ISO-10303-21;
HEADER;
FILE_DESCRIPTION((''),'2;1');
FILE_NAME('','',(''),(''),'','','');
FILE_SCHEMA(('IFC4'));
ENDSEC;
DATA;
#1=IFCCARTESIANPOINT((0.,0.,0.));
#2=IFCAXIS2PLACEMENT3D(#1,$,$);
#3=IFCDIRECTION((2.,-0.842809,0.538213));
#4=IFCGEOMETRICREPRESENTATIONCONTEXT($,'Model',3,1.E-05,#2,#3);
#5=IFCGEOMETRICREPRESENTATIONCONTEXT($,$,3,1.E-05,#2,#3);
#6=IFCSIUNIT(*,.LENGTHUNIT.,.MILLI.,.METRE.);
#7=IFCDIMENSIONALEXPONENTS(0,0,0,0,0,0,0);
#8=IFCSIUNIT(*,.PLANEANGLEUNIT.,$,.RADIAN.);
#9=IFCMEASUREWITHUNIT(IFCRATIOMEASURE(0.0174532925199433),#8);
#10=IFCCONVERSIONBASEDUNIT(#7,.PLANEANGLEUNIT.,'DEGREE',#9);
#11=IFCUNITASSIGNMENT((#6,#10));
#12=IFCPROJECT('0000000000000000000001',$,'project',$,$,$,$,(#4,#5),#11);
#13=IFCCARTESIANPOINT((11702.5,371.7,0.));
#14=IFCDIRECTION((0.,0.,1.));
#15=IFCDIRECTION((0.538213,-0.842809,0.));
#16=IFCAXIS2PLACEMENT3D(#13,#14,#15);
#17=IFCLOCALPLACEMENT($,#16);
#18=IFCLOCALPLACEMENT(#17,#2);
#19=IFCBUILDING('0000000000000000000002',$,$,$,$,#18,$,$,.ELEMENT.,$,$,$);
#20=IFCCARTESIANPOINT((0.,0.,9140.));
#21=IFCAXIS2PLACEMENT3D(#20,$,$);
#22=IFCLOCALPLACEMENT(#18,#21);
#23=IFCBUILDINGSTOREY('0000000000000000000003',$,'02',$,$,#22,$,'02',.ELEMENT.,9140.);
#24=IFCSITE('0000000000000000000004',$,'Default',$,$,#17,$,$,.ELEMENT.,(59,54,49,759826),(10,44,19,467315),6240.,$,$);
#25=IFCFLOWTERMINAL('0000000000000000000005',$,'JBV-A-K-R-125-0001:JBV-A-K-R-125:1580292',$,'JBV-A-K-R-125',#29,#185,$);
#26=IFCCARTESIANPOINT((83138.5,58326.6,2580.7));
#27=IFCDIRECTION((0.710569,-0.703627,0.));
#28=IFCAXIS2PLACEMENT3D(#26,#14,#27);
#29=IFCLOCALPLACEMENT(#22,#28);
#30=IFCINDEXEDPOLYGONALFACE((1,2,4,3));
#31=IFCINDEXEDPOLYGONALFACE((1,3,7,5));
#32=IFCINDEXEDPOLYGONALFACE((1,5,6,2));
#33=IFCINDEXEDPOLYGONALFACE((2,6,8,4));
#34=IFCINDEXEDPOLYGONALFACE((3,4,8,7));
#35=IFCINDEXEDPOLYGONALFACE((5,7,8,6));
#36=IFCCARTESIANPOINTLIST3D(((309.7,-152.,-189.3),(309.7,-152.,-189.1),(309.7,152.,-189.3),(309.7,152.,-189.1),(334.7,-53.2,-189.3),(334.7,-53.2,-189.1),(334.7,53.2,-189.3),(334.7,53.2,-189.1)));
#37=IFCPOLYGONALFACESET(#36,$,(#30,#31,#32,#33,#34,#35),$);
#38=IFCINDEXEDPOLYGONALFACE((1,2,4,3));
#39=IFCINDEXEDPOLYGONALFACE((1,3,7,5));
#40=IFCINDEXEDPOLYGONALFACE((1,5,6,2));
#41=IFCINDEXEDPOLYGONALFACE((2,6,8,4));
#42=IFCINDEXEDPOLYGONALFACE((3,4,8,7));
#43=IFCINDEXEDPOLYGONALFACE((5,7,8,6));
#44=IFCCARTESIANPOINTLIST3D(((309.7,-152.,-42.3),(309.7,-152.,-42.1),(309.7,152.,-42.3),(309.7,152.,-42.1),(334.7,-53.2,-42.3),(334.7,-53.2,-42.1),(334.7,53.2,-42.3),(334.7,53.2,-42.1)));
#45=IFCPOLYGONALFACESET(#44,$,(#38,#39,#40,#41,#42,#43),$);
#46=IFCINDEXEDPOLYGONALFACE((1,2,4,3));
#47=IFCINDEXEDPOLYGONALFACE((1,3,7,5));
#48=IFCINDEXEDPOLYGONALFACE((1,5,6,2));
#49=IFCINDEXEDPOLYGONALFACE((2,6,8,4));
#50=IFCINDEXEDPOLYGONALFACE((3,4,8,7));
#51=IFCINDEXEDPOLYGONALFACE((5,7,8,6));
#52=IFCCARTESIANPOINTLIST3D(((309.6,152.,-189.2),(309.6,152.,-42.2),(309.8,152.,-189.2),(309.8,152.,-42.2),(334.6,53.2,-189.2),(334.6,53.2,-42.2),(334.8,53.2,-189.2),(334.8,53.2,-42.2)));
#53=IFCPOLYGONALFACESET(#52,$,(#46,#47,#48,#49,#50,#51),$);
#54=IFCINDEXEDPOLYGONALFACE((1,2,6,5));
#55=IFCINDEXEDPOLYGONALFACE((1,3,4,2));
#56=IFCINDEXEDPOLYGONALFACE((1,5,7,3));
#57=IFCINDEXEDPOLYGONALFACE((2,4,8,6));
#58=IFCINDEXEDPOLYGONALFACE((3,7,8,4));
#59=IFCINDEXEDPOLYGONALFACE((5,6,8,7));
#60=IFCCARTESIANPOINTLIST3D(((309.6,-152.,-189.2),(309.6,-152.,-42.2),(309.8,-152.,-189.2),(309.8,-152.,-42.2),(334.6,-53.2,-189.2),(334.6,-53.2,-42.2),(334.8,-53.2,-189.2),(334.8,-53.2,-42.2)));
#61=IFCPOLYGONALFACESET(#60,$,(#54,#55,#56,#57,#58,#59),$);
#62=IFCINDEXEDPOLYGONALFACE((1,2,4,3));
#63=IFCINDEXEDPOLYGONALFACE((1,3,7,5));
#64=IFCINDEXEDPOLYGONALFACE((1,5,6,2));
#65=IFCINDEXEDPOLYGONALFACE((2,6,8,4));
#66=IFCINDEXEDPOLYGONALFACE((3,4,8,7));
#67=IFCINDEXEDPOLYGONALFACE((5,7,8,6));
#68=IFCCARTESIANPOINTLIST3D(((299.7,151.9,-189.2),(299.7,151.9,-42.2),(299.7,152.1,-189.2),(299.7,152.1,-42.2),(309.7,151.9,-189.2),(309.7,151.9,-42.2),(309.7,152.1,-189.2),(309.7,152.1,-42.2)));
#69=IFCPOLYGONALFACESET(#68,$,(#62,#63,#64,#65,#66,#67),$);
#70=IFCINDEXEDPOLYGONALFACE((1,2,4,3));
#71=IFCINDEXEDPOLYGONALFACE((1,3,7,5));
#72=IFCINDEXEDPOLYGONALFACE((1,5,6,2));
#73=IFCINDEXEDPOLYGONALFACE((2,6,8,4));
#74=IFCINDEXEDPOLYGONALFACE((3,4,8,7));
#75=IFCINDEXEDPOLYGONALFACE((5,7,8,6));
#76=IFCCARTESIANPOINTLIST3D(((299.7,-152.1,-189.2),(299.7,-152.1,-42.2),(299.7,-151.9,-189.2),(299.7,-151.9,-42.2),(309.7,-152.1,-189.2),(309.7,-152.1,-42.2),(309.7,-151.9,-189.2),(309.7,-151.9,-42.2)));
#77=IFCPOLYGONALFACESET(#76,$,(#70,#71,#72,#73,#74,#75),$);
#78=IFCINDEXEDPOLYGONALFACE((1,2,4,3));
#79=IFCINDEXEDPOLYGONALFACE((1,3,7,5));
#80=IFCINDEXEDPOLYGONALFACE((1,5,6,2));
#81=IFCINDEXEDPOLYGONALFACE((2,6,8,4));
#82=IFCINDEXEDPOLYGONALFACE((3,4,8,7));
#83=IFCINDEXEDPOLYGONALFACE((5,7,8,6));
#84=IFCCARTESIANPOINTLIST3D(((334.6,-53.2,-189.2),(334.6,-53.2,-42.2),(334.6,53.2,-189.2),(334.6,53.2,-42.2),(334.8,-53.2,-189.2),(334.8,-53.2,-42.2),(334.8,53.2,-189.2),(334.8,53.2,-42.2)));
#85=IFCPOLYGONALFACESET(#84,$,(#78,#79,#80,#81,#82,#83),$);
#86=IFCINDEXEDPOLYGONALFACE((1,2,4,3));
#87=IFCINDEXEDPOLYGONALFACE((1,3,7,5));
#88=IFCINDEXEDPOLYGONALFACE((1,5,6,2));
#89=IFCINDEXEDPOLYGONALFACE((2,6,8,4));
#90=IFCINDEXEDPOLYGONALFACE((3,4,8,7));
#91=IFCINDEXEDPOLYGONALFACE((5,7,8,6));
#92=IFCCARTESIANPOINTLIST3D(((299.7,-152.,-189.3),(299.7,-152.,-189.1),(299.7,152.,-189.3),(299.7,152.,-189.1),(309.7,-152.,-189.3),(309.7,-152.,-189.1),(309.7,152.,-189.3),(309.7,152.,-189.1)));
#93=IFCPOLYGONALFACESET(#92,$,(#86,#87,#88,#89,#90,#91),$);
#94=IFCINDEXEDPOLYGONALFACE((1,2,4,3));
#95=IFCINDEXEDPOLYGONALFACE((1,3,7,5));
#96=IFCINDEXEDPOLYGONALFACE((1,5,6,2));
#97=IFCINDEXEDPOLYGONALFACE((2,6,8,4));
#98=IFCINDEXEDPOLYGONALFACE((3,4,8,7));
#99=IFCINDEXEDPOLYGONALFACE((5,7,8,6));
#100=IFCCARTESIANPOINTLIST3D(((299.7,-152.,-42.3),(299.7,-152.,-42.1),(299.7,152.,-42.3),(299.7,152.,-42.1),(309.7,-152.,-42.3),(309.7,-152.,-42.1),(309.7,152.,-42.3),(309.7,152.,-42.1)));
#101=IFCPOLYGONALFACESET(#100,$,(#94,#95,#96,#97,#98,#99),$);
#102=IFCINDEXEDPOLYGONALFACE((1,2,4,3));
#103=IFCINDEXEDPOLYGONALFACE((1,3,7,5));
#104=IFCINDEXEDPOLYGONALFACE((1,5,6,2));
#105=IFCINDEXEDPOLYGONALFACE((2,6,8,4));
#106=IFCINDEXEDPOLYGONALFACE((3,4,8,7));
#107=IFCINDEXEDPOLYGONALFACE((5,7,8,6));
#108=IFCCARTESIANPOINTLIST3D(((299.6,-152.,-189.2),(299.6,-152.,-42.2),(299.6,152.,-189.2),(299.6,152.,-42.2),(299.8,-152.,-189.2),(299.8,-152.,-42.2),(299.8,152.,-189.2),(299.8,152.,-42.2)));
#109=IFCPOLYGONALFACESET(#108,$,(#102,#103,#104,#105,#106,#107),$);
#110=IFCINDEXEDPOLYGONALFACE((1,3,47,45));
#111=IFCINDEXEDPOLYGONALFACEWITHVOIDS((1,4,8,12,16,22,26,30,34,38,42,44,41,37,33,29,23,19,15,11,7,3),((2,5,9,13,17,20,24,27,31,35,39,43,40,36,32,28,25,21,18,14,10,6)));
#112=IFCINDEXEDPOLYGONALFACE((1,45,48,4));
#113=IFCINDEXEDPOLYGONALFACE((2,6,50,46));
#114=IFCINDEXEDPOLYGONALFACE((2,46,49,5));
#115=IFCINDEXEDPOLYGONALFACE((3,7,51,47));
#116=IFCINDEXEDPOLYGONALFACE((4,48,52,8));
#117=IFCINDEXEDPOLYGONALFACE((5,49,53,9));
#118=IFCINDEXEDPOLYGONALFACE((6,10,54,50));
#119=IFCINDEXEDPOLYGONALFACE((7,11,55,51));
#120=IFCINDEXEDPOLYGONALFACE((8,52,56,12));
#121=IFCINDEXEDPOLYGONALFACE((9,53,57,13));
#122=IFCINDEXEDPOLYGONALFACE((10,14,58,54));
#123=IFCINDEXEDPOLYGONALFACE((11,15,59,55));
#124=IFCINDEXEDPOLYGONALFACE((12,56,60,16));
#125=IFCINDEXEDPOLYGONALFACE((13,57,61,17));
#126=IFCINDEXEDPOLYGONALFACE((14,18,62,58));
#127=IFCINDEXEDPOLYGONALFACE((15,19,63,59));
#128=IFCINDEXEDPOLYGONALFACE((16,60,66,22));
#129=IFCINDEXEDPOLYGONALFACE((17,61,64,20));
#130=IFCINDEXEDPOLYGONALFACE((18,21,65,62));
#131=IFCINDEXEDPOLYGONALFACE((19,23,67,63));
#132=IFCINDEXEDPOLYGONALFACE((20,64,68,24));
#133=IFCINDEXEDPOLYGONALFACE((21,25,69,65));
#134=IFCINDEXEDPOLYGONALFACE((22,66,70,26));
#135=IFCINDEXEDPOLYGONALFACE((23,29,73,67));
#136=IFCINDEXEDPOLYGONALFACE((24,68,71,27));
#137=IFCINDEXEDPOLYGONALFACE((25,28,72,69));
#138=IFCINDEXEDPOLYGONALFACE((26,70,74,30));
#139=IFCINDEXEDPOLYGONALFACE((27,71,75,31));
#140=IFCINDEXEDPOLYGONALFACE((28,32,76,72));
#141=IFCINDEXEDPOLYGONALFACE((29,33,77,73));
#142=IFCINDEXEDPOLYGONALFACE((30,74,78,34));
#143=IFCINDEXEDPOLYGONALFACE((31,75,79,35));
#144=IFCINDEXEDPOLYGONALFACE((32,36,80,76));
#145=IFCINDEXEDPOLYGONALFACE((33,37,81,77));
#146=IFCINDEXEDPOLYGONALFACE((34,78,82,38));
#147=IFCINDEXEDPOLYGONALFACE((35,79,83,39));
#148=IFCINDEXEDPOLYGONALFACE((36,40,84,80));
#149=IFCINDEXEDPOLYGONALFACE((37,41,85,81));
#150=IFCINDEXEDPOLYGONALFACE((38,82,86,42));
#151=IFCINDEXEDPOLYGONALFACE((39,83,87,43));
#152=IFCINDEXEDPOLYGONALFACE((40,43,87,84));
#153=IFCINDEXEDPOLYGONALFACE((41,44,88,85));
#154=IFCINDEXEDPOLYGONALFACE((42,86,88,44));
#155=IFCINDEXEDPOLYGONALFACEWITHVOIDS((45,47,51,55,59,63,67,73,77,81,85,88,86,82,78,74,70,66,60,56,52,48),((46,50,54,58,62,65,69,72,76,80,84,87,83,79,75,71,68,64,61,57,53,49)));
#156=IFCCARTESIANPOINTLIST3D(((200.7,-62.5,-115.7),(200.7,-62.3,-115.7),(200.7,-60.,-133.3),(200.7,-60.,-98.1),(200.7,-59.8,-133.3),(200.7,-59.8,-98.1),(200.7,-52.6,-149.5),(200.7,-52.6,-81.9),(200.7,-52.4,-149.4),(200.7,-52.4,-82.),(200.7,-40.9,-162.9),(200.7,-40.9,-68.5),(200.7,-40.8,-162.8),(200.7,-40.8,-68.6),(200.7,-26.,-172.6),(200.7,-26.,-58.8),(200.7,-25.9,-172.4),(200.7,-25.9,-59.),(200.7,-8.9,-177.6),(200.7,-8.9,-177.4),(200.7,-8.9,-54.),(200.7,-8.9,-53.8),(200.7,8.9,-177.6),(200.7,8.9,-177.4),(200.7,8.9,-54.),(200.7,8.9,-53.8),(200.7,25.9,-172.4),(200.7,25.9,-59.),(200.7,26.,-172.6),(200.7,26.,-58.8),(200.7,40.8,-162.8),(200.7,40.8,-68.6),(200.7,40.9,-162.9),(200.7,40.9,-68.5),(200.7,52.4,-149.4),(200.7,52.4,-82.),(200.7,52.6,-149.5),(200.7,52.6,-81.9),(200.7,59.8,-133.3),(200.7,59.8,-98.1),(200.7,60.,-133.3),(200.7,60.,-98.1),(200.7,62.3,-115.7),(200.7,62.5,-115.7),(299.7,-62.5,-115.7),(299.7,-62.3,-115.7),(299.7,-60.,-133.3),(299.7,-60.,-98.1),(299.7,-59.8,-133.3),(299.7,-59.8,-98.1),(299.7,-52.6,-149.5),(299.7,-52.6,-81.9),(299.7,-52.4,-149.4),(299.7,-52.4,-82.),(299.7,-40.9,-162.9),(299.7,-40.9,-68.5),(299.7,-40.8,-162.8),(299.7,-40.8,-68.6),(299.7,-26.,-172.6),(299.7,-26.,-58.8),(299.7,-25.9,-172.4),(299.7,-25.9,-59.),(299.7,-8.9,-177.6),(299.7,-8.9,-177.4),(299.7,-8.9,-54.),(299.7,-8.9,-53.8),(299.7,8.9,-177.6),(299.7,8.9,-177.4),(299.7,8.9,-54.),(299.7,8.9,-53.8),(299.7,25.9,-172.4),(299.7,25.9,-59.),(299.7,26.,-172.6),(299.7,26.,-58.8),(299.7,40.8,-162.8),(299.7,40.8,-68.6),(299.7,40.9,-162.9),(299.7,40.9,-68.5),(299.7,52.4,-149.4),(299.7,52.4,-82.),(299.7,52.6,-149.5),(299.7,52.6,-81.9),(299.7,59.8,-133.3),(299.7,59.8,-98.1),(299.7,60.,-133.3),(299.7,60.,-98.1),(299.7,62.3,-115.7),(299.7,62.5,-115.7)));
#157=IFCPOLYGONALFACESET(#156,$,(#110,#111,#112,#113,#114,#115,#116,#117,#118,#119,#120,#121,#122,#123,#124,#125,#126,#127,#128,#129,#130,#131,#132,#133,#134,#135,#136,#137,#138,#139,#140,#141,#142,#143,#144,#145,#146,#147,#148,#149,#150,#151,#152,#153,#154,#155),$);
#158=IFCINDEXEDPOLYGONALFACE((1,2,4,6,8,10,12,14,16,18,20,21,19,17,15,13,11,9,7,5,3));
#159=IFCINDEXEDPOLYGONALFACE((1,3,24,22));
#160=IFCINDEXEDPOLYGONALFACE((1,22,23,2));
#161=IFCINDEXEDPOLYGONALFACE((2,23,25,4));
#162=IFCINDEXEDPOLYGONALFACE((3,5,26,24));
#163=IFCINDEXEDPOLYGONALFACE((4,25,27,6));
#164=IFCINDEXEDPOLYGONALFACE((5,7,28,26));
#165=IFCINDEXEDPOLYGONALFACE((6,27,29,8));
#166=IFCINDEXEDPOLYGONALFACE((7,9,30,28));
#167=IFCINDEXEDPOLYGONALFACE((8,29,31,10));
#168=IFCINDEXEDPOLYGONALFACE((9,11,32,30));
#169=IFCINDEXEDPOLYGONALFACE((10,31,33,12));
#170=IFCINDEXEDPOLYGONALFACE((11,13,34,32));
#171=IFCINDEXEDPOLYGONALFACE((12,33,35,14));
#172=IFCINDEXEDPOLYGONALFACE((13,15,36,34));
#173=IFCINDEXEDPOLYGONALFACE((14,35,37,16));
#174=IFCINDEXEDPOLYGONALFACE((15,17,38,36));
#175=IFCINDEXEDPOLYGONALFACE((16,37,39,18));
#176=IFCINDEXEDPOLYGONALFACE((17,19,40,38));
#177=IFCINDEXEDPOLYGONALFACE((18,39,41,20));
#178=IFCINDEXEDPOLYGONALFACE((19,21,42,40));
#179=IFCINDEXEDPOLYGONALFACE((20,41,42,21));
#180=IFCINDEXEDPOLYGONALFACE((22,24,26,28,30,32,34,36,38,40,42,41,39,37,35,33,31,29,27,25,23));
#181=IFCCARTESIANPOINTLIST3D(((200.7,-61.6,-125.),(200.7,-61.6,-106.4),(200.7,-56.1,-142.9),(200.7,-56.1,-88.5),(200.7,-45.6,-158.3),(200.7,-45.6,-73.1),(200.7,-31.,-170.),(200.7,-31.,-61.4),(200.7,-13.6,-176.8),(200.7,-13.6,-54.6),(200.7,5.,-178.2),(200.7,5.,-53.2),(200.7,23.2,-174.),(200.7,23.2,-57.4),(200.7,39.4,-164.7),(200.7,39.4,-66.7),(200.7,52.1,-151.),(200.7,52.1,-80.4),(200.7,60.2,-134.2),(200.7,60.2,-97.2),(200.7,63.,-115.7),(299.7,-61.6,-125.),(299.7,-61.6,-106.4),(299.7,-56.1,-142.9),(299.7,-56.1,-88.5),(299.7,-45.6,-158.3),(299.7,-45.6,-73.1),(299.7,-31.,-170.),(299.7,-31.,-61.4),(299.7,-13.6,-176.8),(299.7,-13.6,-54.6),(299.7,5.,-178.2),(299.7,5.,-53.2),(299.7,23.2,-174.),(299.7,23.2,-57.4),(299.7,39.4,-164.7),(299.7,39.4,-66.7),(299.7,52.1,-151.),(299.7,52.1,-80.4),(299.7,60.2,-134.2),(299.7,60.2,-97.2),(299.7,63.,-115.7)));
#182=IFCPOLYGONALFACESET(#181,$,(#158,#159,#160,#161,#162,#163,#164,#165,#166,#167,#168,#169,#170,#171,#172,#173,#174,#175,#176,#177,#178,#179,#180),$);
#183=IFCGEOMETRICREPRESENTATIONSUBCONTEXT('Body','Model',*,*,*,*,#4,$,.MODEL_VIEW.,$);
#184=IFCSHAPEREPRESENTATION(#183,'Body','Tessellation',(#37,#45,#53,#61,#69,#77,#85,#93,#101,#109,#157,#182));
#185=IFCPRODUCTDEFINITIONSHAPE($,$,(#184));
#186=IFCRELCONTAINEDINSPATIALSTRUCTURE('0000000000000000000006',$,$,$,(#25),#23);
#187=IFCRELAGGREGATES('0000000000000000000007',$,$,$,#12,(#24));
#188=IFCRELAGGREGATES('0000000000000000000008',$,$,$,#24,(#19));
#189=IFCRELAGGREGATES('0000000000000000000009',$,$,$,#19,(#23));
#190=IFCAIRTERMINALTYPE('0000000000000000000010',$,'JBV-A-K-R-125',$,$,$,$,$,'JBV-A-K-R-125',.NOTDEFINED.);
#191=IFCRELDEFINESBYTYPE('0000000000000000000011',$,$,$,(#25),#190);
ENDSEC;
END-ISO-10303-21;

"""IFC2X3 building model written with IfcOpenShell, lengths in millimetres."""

from ifc_helpers import new_model, entity, si_unit, converted_unit, direction, frame, frame_2d, origin, origin_2d_with_axis, place, context, subcontext, project, spatial, polyline, circle_curve, parameter, trimmed, segment, composite_curve, rectangle, circle, outline, extrude, source, transform, mapped, type_object, type_shapes, element, save


model = new_model("IFC2X3")

# Units and contexts
model_context = context("Model", 3, precision=1e-05, world=origin(), true_north=direction((2.0, -0.842809, 0.538213)))
context_of_model = context(None, 3, precision=1e-05, world=origin(), true_north=direction((2.0, -0.842809, 0.538213)))
body_context = subcontext(model_context, "Body", "Model", "MODEL_VIEW")
ifc_project = project(units=[si_unit("LENGTHUNIT", "METRE", prefix="MILLI"), converted_unit("PLANEANGLEUNIT", "DEGREE", entity("IfcRatioMeasure", 0.0174532925199433), si_unit("PLANEANGLEUNIT", "RADIAN"), dimensions=[0, 0, 0, 0, 0, 0, 0])], contexts=[model_context, context_of_model])

# Site, building, storey
site_placement = place(None, frame((11702.5, 371.7, 0.0), z_axis=(0.0, 0.0, 1.0), x_axis=(0.538213, -0.842809, 0.0)))
site = spatial("IfcSite", under=ifc_project, at=site_placement, Name="Default", CompositionType="ELEMENT", RefLatitude=(59, 54, 49, 759826), RefLongitude=(10, 44, 19, 467315), RefElevation=6240.0)
building_placement = place(site_placement, origin())
building = spatial("IfcBuilding", under=site, at=building_placement, CompositionType="ELEMENT")
storey_placement = place(building_placement, frame((0.0, 0.0, 9140.0)))
storey = spatial("IfcBuildingStorey", under=building, at=storey_placement, Name="02", LongName="02", CompositionType="ELEMENT", Elevation=9140.0)

# Flow terminal
air_terminal_type_1 = type_object("IfcAirTerminalType", Name="JBV-A-K-R-125", ElementType="JBV-A-K-R-125", PredefinedType="NOTDEFINED")
shared_shape_1 = source(origin(), body_context, "Body", "SweptSolid", [
    extrude(outline(polyline([(-152.0, -12.5), (152.0, -12.5), (53.2, 12.5), (-53.2, 12.5), (-152.0, -12.5)])), frame((322.2, 0.0, -189.3), z_axis=(0.0, 0.0, 1.0), x_axis=(0.0, -1.0, 0.0)), (0.0, 0.0, 1.0), 0.2),
    extrude(outline(polyline([(-152.0, -12.5), (152.0, -12.5), (53.2, 12.5), (-53.2, 12.5), (-152.0, -12.5)])), frame((322.2, 0.0, -42.3), z_axis=(0.0, 0.0, 1.0), x_axis=(0.0, -1.0, 0.0)), (0.0, 0.0, 1.0), 0.2),
    extrude(rectangle(XDim=0.2, YDim=101.9, at=frame_2d((0.0, 0.0), x_axis=(1.0, 0.0))), frame((322.2, 102.6, -189.2), z_axis=(0.0, 0.0, 1.0), x_axis=(0.969446, 0.245305, 0.0)), (0.0, 0.0, 1.0), 147.0),
    extrude(rectangle(XDim=0.2, YDim=101.9, at=frame_2d((0.0, 0.0), x_axis=(1.0, 0.0))), frame((322.2, -102.6, -189.2), z_axis=(0.0, 0.0, 1.0), x_axis=(-0.969446, 0.245305, 0.0)), (0.0, 0.0, 1.0), 147.0),
    extrude(rectangle(XDim=0.2, YDim=10.0, at=frame_2d((0.0, 0.0), x_axis=(1.0, 0.0))), frame((304.7, 152.0, -189.2), z_axis=(0.0, 0.0, 1.0), x_axis=(0.0, 1.0, 0.0)), (0.0, 0.0, 1.0), 147.0),
    extrude(rectangle(XDim=0.2, YDim=10.0, at=frame_2d((0.0, 0.0), x_axis=(1.0, 0.0))), frame((304.7, -152.0, -189.2), z_axis=(0.0, 0.0, 1.0), x_axis=(0.0, 1.0, 0.0)), (0.0, 0.0, 1.0), 147.0),
    extrude(rectangle(XDim=0.2, YDim=106.4, at=frame_2d((0.0, 0.0), x_axis=(1.0, 0.0))), frame((334.7, 0.0, -189.2)), (0.0, 0.0, 1.0), 147.0),
    extrude(rectangle(XDim=304.0, YDim=10.0, at=frame_2d((0.0, 0.0), x_axis=(1.0, 0.0))), frame((304.7, 0.0, -189.3), z_axis=(0.0, 0.0, 1.0), x_axis=(0.0, -1.0, 0.0)), (0.0, 0.0, 1.0), 0.2),
    extrude(rectangle(XDim=304.0, YDim=10.0, at=frame_2d((0.0, 0.0), x_axis=(1.0, 0.0))), frame((304.7, 0.0, -42.3), z_axis=(0.0, 0.0, 1.0), x_axis=(0.0, -1.0, 0.0)), (0.0, 0.0, 1.0), 0.2),
    extrude(rectangle(XDim=0.2, YDim=304.0, at=frame_2d((0.0, 0.0), x_axis=(1.0, 0.0))), frame((299.7, 0.0, -189.2)), (0.0, 0.0, 1.0), 147.0),
    extrude(outline(composite_curve([segment(trimmed(circle_curve(origin_2d_with_axis(), 62.5), [parameter(0.0)], [parameter(180.0)], True, "PARAMETER"), True, "CONTINUOUS"), segment(trimmed(circle_curve(origin_2d_with_axis(), 62.5), [parameter(180.0)], [parameter(360.0)], True, "PARAMETER"), True, "CONTINUOUS")], self_intersect=False), holes=[composite_curve([segment(trimmed(circle_curve(origin_2d_with_axis(), 62.3), [parameter(180.0)], [parameter(360.0)], True, "PARAMETER"), False, "CONTINUOUS"), segment(trimmed(circle_curve(origin_2d_with_axis(), 62.3), [parameter(0.0)], [parameter(180.0)], True, "PARAMETER"), False, "CONTINUOUS")], self_intersect=False)]), frame((200.7, 0.0, -115.7), z_axis=(1.0, 0.0, 0.0), x_axis=(0.0, 1.0, 0.0)), (0.0, 0.0, 1.0), 99.0),
    extrude(circle(Radius=62.6, at=frame_2d((0.0, 0.0), x_axis=(1.0, 0.0))), frame((200.7, 0.3, -115.7), z_axis=(1.0, 0.0, 0.0), x_axis=(0.0, 1.0, 0.0)), (0.0, 0.0, 1.0), 99.0),
])
type_shapes(air_terminal_type_1, [shared_shape_1])
for number, where, z_axis, x_axis, name in (
    (1, (83138.5, 58326.6, 2580.7), (0.0, 0.0, 1.0), (0.710569, -0.703627, 0.0), "JBV-A-K-R-125-0001:JBV-A-K-R-125:1580292"),
):
    element("IfcFlowTerminal", number, at=place(storey_placement, frame(where, z_axis=z_axis, x_axis=x_axis)), inside=storey, type_object=air_terminal_type_1, Name=name, ObjectType="JBV-A-K-R-125", context=body_context, shape_type="MappedRepresentation", body=[
        mapped(shared_shape_1, transform((0.0, 0.0, 0.0), scale=1.0)),
    ])

save(model, "model.ifc")
